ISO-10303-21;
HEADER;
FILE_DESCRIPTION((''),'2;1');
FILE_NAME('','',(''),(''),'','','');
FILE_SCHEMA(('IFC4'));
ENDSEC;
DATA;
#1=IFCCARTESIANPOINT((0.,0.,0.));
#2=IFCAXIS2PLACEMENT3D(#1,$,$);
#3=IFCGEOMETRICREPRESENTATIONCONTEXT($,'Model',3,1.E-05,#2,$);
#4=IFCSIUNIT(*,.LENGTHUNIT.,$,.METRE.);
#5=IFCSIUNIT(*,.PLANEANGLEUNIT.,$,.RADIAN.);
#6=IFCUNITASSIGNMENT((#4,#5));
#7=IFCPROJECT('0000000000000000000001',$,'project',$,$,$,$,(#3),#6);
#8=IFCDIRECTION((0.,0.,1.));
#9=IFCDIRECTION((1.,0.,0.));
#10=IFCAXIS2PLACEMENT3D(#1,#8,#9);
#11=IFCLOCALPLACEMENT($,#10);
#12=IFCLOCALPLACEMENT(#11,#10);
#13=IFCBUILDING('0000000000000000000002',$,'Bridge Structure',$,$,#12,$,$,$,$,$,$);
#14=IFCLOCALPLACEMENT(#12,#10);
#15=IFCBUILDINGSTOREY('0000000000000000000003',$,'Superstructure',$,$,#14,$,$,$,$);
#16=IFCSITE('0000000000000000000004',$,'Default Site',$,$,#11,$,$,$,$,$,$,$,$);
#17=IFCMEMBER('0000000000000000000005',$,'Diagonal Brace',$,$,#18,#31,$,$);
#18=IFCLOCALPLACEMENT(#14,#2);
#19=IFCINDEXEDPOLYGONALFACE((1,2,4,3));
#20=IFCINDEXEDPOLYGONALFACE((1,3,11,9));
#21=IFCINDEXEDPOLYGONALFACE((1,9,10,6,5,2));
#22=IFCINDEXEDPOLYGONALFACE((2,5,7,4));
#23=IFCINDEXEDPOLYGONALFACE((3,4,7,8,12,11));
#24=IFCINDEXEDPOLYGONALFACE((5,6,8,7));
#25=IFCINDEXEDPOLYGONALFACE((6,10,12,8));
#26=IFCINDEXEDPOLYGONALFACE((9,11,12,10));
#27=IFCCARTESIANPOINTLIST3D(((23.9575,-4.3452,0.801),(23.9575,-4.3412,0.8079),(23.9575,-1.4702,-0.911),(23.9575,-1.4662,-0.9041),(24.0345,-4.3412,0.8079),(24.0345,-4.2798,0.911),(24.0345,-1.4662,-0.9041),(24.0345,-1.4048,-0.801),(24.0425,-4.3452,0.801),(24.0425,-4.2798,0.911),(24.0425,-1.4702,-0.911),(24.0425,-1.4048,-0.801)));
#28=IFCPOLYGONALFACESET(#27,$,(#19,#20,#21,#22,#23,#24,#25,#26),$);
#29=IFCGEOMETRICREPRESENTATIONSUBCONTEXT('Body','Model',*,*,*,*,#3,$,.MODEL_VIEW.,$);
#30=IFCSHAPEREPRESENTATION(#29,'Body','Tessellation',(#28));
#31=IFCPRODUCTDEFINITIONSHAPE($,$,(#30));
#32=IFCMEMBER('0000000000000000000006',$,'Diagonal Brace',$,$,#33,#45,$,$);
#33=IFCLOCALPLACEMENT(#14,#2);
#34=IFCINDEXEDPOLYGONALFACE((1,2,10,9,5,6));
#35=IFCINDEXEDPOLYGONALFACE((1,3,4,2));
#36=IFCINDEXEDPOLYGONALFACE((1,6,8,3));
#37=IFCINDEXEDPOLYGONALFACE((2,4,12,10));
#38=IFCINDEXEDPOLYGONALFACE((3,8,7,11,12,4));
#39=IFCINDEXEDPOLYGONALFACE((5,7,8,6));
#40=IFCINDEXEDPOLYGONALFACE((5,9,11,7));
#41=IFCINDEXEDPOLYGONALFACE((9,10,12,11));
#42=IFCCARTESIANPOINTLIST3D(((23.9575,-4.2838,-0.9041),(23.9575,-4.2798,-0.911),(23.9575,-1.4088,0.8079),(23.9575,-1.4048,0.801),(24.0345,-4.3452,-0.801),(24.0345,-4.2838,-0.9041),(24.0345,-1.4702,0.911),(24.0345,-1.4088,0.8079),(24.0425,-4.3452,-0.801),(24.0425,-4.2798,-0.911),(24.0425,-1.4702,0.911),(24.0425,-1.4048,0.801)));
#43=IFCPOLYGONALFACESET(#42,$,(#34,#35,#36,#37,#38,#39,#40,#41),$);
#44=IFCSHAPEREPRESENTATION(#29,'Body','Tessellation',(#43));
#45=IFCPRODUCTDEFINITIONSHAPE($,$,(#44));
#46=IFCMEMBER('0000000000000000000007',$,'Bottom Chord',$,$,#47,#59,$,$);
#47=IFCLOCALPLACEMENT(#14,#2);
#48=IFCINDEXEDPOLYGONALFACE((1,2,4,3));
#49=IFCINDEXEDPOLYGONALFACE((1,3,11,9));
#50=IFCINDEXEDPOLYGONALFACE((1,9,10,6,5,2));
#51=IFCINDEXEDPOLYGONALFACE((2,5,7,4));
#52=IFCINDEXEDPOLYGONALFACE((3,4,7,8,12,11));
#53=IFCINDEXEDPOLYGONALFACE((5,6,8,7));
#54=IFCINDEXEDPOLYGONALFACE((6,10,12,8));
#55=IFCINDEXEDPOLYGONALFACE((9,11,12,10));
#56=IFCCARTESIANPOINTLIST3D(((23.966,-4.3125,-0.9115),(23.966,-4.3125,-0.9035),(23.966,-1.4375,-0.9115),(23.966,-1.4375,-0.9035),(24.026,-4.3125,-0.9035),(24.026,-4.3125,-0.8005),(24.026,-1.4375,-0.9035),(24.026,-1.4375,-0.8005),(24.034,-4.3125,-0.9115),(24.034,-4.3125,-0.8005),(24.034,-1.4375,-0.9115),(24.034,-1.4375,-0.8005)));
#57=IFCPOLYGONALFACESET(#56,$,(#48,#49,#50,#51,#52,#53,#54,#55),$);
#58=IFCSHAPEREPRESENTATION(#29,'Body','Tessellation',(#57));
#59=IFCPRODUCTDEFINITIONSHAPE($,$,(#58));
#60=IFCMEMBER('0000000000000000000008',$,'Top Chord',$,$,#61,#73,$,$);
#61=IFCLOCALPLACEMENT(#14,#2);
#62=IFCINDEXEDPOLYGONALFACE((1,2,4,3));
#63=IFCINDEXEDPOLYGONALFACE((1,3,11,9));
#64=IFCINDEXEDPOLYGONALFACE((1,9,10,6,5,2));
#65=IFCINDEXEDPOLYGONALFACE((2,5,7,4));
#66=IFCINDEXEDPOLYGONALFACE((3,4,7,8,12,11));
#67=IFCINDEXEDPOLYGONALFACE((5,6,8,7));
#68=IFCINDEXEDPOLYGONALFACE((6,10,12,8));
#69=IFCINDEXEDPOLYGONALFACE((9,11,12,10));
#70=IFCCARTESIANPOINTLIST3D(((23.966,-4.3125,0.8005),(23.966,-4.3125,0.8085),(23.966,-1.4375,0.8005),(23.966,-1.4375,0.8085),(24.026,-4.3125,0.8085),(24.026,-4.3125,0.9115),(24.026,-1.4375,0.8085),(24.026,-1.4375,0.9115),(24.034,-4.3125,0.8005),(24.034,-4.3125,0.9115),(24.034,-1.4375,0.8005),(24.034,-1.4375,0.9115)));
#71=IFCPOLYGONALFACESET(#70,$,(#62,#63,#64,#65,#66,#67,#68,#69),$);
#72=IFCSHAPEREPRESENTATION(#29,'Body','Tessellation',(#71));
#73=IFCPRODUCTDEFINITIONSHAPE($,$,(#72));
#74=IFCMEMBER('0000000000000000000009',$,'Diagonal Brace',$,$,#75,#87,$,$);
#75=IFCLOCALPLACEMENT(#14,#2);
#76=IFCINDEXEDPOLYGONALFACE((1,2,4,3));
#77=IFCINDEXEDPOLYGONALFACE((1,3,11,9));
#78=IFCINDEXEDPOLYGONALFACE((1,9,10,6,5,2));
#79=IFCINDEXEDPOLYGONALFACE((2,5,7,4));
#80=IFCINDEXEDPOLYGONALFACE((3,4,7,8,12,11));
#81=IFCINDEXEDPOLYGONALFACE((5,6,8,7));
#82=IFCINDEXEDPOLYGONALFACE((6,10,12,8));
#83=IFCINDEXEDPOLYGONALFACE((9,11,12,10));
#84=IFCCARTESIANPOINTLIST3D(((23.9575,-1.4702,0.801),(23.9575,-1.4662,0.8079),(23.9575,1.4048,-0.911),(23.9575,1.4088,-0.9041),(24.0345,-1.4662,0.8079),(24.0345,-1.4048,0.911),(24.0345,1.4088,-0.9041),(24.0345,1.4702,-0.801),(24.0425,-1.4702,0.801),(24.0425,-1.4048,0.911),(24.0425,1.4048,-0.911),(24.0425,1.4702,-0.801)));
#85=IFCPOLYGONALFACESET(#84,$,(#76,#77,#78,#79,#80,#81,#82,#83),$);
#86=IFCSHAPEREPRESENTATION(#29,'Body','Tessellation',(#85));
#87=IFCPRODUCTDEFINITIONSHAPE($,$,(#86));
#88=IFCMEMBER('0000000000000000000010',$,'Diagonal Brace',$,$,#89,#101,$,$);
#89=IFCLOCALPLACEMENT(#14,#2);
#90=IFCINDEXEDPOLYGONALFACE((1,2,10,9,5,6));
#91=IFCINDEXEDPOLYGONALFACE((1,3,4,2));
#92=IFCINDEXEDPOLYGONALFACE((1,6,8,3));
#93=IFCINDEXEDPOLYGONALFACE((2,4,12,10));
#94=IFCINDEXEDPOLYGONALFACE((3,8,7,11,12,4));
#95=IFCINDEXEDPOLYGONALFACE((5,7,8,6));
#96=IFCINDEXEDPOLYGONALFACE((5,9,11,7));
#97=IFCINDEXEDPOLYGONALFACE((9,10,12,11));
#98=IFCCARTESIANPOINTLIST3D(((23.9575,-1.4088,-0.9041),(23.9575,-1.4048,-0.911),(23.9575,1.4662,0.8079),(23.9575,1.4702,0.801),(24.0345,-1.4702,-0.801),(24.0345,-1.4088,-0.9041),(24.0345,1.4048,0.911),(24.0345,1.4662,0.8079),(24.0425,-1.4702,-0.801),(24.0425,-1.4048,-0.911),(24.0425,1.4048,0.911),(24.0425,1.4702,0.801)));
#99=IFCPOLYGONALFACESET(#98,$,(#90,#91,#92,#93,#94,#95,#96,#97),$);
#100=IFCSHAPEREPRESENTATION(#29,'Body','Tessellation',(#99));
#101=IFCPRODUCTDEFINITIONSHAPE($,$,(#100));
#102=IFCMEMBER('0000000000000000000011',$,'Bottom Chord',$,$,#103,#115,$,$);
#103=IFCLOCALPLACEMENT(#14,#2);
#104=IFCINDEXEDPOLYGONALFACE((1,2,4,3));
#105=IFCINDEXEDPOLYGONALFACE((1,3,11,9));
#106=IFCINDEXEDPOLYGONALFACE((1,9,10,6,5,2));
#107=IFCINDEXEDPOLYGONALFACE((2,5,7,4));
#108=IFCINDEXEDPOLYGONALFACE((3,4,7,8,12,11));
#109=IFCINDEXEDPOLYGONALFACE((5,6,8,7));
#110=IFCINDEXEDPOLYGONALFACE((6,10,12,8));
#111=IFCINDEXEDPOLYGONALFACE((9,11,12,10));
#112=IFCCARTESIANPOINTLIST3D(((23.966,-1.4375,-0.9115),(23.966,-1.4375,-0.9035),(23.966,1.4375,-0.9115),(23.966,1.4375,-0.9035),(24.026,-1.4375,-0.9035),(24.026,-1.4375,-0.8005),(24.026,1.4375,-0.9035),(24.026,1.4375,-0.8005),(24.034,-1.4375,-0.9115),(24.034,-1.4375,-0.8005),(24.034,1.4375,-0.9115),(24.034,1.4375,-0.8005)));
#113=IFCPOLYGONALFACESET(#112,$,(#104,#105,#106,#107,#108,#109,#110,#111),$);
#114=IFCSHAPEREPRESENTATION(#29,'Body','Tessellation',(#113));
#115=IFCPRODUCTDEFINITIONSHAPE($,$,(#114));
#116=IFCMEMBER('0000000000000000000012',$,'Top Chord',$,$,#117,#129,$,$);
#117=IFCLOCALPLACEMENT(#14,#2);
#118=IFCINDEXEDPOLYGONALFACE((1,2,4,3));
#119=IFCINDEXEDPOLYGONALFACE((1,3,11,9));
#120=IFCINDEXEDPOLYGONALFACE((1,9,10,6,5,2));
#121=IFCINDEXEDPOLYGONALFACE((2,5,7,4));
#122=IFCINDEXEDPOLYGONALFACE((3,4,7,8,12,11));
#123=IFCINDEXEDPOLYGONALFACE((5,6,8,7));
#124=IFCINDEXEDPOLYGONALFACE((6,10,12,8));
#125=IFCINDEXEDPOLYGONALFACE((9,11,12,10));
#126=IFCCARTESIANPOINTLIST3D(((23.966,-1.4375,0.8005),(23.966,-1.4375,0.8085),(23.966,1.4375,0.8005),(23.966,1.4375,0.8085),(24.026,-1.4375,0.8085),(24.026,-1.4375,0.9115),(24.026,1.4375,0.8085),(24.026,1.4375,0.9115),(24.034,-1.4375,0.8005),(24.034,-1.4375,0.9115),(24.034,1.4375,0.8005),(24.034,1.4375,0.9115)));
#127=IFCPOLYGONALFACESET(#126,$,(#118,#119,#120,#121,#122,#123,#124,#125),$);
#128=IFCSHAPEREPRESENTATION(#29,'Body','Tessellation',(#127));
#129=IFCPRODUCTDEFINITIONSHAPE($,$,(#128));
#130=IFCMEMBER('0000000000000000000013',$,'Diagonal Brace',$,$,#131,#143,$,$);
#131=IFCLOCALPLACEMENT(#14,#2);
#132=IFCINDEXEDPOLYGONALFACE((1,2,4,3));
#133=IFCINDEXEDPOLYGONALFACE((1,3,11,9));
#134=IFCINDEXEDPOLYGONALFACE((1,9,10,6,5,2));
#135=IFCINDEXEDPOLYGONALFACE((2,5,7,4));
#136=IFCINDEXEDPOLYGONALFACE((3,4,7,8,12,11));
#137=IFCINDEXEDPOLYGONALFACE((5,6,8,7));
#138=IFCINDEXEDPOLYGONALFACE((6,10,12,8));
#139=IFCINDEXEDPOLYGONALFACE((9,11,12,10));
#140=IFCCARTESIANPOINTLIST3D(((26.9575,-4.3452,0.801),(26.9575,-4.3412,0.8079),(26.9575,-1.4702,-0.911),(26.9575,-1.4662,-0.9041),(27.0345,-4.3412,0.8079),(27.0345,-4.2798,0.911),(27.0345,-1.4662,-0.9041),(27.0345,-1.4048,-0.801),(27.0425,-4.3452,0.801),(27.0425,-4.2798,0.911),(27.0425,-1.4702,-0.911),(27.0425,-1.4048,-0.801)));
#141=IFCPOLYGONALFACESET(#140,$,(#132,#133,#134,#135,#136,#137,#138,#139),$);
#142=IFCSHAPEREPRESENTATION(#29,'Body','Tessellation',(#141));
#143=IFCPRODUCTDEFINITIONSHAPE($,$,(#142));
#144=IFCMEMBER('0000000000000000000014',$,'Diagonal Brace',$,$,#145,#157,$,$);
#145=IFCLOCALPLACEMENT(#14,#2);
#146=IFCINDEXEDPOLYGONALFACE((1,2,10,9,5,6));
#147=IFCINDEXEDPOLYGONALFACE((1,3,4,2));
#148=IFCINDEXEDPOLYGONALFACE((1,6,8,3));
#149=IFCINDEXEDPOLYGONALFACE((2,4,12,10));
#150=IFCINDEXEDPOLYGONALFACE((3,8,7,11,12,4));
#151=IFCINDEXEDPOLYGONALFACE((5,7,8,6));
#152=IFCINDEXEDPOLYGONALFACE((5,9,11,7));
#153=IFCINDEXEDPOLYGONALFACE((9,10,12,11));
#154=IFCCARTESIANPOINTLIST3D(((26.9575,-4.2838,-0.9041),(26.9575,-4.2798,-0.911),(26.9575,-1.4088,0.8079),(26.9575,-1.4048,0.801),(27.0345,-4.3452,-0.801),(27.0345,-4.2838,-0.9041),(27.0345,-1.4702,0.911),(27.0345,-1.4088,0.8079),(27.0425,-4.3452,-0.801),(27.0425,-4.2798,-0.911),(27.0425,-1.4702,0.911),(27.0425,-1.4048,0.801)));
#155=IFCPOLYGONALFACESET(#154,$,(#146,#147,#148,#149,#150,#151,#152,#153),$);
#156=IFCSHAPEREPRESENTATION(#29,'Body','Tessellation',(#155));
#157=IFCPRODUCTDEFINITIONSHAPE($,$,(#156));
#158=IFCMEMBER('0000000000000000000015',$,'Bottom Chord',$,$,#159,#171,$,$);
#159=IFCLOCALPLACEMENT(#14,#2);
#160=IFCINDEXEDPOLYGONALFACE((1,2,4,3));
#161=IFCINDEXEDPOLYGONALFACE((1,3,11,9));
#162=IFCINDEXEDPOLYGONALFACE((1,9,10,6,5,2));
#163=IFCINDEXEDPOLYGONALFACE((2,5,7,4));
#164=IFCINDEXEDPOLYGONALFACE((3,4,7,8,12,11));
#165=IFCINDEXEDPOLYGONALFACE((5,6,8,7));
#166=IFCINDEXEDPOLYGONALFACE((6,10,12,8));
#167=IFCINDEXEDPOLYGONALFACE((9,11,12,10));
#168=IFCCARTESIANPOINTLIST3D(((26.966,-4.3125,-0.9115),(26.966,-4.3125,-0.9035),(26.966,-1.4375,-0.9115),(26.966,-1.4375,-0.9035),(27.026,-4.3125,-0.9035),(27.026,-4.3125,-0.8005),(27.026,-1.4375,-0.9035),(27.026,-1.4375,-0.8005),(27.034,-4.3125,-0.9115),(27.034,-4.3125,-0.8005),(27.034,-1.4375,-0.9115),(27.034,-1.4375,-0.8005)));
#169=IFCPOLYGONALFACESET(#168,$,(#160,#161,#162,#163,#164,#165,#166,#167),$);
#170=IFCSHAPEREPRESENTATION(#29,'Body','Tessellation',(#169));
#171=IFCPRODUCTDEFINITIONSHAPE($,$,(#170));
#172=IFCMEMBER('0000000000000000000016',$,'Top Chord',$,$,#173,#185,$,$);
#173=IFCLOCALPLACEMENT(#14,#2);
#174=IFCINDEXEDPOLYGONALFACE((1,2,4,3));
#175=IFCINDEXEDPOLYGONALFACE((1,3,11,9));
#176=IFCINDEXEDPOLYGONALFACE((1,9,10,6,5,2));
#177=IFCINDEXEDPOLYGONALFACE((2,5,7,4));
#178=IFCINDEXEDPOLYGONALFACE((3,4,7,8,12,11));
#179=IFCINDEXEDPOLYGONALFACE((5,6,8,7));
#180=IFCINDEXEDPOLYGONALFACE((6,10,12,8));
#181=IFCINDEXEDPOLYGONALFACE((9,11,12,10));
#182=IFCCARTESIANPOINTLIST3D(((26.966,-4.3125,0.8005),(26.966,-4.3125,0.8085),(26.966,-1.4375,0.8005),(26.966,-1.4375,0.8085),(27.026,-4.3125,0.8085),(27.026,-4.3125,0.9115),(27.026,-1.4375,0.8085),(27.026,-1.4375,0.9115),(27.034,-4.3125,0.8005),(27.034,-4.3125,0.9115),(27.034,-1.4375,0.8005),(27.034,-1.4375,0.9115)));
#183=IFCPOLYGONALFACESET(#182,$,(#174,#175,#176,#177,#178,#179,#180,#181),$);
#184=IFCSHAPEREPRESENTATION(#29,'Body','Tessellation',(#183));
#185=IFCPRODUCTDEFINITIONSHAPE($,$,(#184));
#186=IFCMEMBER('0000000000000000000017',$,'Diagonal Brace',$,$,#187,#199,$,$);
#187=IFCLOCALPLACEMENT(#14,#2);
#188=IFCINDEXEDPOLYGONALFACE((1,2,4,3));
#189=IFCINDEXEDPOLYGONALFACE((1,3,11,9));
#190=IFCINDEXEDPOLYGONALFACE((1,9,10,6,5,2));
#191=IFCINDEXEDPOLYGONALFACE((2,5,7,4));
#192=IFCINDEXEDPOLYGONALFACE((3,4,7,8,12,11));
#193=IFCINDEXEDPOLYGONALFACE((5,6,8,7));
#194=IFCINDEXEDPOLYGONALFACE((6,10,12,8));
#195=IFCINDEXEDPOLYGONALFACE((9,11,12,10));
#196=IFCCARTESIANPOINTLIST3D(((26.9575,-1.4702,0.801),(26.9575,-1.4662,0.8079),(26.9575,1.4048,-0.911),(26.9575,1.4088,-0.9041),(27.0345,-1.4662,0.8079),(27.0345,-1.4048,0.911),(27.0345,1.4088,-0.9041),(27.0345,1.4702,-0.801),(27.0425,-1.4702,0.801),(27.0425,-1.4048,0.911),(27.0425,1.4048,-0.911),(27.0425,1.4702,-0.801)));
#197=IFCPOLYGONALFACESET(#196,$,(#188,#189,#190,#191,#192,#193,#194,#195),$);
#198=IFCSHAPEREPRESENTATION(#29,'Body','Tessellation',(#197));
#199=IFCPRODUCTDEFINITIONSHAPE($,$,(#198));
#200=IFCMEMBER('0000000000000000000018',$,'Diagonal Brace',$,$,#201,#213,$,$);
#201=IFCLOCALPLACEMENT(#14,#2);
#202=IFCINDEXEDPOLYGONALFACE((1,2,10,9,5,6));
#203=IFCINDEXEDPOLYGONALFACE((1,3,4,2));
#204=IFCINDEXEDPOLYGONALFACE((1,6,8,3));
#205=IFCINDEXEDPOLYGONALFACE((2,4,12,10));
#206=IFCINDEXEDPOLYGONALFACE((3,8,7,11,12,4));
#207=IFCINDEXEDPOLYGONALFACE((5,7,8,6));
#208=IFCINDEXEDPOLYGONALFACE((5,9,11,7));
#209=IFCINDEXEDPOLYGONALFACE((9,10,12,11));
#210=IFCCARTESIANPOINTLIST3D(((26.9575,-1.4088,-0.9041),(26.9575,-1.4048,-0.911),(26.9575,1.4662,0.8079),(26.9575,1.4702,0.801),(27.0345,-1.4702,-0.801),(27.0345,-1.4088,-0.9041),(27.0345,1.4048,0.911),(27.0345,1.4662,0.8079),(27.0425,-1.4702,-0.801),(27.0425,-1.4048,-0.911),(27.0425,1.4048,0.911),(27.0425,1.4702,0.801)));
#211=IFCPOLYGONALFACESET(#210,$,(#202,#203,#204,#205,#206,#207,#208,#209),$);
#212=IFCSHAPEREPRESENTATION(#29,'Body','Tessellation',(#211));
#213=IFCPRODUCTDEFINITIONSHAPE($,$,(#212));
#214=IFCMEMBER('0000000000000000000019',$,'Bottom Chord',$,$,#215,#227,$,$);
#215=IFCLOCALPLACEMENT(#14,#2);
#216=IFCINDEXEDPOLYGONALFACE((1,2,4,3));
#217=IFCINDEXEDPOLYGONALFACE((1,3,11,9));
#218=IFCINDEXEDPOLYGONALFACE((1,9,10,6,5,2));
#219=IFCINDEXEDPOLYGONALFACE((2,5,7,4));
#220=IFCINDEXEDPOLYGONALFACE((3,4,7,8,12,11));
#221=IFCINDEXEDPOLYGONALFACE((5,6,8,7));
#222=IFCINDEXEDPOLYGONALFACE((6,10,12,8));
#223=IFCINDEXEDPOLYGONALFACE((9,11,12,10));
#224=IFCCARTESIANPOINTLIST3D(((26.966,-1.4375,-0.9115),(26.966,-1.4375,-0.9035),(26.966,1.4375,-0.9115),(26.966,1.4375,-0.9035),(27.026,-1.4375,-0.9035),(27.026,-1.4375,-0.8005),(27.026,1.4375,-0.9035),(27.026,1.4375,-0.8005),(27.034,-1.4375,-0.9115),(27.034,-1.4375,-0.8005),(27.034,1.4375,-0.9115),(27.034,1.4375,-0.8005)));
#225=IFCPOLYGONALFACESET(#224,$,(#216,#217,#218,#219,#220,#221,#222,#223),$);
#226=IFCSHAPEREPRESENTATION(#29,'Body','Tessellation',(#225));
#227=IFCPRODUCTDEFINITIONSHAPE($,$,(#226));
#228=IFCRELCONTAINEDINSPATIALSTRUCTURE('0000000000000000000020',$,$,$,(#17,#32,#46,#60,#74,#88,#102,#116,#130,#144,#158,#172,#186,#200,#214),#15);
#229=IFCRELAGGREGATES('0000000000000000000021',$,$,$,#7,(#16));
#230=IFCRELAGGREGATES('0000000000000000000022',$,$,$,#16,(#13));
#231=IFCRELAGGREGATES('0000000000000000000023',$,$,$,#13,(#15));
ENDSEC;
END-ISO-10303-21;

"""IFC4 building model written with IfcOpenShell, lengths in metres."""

from ifc_helpers import new_model, si_unit, frame, origin, origin_with_axes, origin_2d_with_axis, place, context, subcontext, project, spatial, l_section, extrude, element, save


model = new_model("IFC4")

# Units and contexts
model_context = context("Model", 3, precision=1e-05, world=origin())
body_context = subcontext(model_context, "Body", "Model", "MODEL_VIEW")
ifc_project = project(units=[si_unit("LENGTHUNIT", "METRE"), si_unit("PLANEANGLEUNIT", "RADIAN")], contexts=[model_context])

# Site, building, storey
site_placement = place(None, origin_with_axes())
site = spatial("IfcSite", under=ifc_project, at=site_placement, Name="Default Site")
building_placement = place(site_placement, origin_with_axes())
building = spatial("IfcBuilding", under=site, at=building_placement, Name="Bridge Structure")
storey_placement = place(building_placement, origin_with_axes())
storey = spatial("IfcBuildingStorey", under=building, at=storey_placement, Name="Superstructure")

# Members
for number, where, z_axis, x_axis, name in (
    (1, (24.0, -4.3125, 0.856), (0.0, 0.859202, -0.511636), (-1.0, 0.0, 0.0), "Diagonal Brace"),
    (2, (24.0, -4.3125, -0.856), (0.0, 0.859202, 0.511636), (-1.0, 0.0, 0.0), "Diagonal Brace"),
):
    element("IfcMember", number, at=place(storey_placement, frame(where, z_axis=z_axis, x_axis=x_axis)), inside=storey, Name=name, context=body_context, shape_type="SweptSolid", body=[
        extrude(l_section(Depth=0.128, Width=0.085, Thickness=0.008, at=origin_2d_with_axis()), origin_with_axes(), (0.0, 0.0, 1.0), 3.3461),
    ])
for number, where, z_axis, x_axis, name in (
    (3, (24.0, -4.3125, -0.856), (0.0, 1.0, 0.0), (-1.0, 0.0, 0.0), "Bottom Chord"),
    (4, (24.0, -4.3125, 0.856), (0.0, 1.0, 0.0), (-1.0, 0.0, 0.0), "Top Chord"),
):
    element("IfcMember", number, at=place(storey_placement, frame(where, z_axis=z_axis, x_axis=x_axis)), inside=storey, Name=name, context=body_context, shape_type="SweptSolid", body=[
        extrude(l_section(Depth=0.111, Width=0.068, Thickness=0.008, at=origin_2d_with_axis()), origin_with_axes(), (0.0, 0.0, 1.0), 2.875),
    ])
for number, where, z_axis, x_axis, name in (
    (5, (24.0, -1.4375, 0.856), (0.0, 0.859202, -0.511636), (-1.0, 0.0, 0.0), "Diagonal Brace"),
    (6, (24.0, -1.4375, -0.856), (0.0, 0.859202, 0.511636), (-1.0, 0.0, 0.0), "Diagonal Brace"),
):
    element("IfcMember", number, at=place(storey_placement, frame(where, z_axis=z_axis, x_axis=x_axis)), inside=storey, Name=name, context=body_context, shape_type="SweptSolid", body=[
        extrude(l_section(Depth=0.128, Width=0.085, Thickness=0.008, at=origin_2d_with_axis()), origin_with_axes(), (0.0, 0.0, 1.0), 3.3461),
    ])
for number, where, z_axis, x_axis, name in (
    (7, (24.0, -1.4375, -0.856), (0.0, 1.0, 0.0), (-1.0, 0.0, 0.0), "Bottom Chord"),
    (8, (24.0, -1.4375, 0.856), (0.0, 1.0, 0.0), (-1.0, 0.0, 0.0), "Top Chord"),
):
    element("IfcMember", number, at=place(storey_placement, frame(where, z_axis=z_axis, x_axis=x_axis)), inside=storey, Name=name, context=body_context, shape_type="SweptSolid", body=[
        extrude(l_section(Depth=0.111, Width=0.068, Thickness=0.008, at=origin_2d_with_axis()), origin_with_axes(), (0.0, 0.0, 1.0), 2.875),
    ])
for number, where, z_axis, x_axis, name in (
    (9, (27.0, -4.3125, 0.856), (0.0, 0.859202, -0.511636), (-1.0, 0.0, 0.0), "Diagonal Brace"),
    (10, (27.0, -4.3125, -0.856), (0.0, 0.859202, 0.511636), (-1.0, 0.0, 0.0), "Diagonal Brace"),
):
    element("IfcMember", number, at=place(storey_placement, frame(where, z_axis=z_axis, x_axis=x_axis)), inside=storey, Name=name, context=body_context, shape_type="SweptSolid", body=[
        extrude(l_section(Depth=0.128, Width=0.085, Thickness=0.008, at=origin_2d_with_axis()), origin_with_axes(), (0.0, 0.0, 1.0), 3.3461),
    ])
for number, where, z_axis, x_axis, name in (
    (11, (27.0, -4.3125, -0.856), (0.0, 1.0, 0.0), (-1.0, 0.0, 0.0), "Bottom Chord"),
    (12, (27.0, -4.3125, 0.856), (0.0, 1.0, 0.0), (-1.0, 0.0, 0.0), "Top Chord"),
):
    element("IfcMember", number, at=place(storey_placement, frame(where, z_axis=z_axis, x_axis=x_axis)), inside=storey, Name=name, context=body_context, shape_type="SweptSolid", body=[
        extrude(l_section(Depth=0.111, Width=0.068, Thickness=0.008, at=origin_2d_with_axis()), origin_with_axes(), (0.0, 0.0, 1.0), 2.875),
    ])
for number, where, z_axis, x_axis, name in (
    (13, (27.0, -1.4375, 0.856), (0.0, 0.859202, -0.511636), (-1.0, 0.0, 0.0), "Diagonal Brace"),
    (14, (27.0, -1.4375, -0.856), (0.0, 0.859202, 0.511636), (-1.0, 0.0, 0.0), "Diagonal Brace"),
):
    element("IfcMember", number, at=place(storey_placement, frame(where, z_axis=z_axis, x_axis=x_axis)), inside=storey, Name=name, context=body_context, shape_type="SweptSolid", body=[
        extrude(l_section(Depth=0.128, Width=0.085, Thickness=0.008, at=origin_2d_with_axis()), origin_with_axes(), (0.0, 0.0, 1.0), 3.3461),
    ])
for number, where, z_axis, x_axis, name in (
    (15, (27.0, -1.4375, -0.856), (0.0, 1.0, 0.0), (-1.0, 0.0, 0.0), "Bottom Chord"),
):
    element("IfcMember", number, at=place(storey_placement, frame(where, z_axis=z_axis, x_axis=x_axis)), inside=storey, Name=name, context=body_context, shape_type="SweptSolid", body=[
        extrude(l_section(Depth=0.111, Width=0.068, Thickness=0.008, at=origin_2d_with_axis()), origin_with_axes(), (0.0, 0.0, 1.0), 2.875),
    ])

save(model, "model.ifc")
